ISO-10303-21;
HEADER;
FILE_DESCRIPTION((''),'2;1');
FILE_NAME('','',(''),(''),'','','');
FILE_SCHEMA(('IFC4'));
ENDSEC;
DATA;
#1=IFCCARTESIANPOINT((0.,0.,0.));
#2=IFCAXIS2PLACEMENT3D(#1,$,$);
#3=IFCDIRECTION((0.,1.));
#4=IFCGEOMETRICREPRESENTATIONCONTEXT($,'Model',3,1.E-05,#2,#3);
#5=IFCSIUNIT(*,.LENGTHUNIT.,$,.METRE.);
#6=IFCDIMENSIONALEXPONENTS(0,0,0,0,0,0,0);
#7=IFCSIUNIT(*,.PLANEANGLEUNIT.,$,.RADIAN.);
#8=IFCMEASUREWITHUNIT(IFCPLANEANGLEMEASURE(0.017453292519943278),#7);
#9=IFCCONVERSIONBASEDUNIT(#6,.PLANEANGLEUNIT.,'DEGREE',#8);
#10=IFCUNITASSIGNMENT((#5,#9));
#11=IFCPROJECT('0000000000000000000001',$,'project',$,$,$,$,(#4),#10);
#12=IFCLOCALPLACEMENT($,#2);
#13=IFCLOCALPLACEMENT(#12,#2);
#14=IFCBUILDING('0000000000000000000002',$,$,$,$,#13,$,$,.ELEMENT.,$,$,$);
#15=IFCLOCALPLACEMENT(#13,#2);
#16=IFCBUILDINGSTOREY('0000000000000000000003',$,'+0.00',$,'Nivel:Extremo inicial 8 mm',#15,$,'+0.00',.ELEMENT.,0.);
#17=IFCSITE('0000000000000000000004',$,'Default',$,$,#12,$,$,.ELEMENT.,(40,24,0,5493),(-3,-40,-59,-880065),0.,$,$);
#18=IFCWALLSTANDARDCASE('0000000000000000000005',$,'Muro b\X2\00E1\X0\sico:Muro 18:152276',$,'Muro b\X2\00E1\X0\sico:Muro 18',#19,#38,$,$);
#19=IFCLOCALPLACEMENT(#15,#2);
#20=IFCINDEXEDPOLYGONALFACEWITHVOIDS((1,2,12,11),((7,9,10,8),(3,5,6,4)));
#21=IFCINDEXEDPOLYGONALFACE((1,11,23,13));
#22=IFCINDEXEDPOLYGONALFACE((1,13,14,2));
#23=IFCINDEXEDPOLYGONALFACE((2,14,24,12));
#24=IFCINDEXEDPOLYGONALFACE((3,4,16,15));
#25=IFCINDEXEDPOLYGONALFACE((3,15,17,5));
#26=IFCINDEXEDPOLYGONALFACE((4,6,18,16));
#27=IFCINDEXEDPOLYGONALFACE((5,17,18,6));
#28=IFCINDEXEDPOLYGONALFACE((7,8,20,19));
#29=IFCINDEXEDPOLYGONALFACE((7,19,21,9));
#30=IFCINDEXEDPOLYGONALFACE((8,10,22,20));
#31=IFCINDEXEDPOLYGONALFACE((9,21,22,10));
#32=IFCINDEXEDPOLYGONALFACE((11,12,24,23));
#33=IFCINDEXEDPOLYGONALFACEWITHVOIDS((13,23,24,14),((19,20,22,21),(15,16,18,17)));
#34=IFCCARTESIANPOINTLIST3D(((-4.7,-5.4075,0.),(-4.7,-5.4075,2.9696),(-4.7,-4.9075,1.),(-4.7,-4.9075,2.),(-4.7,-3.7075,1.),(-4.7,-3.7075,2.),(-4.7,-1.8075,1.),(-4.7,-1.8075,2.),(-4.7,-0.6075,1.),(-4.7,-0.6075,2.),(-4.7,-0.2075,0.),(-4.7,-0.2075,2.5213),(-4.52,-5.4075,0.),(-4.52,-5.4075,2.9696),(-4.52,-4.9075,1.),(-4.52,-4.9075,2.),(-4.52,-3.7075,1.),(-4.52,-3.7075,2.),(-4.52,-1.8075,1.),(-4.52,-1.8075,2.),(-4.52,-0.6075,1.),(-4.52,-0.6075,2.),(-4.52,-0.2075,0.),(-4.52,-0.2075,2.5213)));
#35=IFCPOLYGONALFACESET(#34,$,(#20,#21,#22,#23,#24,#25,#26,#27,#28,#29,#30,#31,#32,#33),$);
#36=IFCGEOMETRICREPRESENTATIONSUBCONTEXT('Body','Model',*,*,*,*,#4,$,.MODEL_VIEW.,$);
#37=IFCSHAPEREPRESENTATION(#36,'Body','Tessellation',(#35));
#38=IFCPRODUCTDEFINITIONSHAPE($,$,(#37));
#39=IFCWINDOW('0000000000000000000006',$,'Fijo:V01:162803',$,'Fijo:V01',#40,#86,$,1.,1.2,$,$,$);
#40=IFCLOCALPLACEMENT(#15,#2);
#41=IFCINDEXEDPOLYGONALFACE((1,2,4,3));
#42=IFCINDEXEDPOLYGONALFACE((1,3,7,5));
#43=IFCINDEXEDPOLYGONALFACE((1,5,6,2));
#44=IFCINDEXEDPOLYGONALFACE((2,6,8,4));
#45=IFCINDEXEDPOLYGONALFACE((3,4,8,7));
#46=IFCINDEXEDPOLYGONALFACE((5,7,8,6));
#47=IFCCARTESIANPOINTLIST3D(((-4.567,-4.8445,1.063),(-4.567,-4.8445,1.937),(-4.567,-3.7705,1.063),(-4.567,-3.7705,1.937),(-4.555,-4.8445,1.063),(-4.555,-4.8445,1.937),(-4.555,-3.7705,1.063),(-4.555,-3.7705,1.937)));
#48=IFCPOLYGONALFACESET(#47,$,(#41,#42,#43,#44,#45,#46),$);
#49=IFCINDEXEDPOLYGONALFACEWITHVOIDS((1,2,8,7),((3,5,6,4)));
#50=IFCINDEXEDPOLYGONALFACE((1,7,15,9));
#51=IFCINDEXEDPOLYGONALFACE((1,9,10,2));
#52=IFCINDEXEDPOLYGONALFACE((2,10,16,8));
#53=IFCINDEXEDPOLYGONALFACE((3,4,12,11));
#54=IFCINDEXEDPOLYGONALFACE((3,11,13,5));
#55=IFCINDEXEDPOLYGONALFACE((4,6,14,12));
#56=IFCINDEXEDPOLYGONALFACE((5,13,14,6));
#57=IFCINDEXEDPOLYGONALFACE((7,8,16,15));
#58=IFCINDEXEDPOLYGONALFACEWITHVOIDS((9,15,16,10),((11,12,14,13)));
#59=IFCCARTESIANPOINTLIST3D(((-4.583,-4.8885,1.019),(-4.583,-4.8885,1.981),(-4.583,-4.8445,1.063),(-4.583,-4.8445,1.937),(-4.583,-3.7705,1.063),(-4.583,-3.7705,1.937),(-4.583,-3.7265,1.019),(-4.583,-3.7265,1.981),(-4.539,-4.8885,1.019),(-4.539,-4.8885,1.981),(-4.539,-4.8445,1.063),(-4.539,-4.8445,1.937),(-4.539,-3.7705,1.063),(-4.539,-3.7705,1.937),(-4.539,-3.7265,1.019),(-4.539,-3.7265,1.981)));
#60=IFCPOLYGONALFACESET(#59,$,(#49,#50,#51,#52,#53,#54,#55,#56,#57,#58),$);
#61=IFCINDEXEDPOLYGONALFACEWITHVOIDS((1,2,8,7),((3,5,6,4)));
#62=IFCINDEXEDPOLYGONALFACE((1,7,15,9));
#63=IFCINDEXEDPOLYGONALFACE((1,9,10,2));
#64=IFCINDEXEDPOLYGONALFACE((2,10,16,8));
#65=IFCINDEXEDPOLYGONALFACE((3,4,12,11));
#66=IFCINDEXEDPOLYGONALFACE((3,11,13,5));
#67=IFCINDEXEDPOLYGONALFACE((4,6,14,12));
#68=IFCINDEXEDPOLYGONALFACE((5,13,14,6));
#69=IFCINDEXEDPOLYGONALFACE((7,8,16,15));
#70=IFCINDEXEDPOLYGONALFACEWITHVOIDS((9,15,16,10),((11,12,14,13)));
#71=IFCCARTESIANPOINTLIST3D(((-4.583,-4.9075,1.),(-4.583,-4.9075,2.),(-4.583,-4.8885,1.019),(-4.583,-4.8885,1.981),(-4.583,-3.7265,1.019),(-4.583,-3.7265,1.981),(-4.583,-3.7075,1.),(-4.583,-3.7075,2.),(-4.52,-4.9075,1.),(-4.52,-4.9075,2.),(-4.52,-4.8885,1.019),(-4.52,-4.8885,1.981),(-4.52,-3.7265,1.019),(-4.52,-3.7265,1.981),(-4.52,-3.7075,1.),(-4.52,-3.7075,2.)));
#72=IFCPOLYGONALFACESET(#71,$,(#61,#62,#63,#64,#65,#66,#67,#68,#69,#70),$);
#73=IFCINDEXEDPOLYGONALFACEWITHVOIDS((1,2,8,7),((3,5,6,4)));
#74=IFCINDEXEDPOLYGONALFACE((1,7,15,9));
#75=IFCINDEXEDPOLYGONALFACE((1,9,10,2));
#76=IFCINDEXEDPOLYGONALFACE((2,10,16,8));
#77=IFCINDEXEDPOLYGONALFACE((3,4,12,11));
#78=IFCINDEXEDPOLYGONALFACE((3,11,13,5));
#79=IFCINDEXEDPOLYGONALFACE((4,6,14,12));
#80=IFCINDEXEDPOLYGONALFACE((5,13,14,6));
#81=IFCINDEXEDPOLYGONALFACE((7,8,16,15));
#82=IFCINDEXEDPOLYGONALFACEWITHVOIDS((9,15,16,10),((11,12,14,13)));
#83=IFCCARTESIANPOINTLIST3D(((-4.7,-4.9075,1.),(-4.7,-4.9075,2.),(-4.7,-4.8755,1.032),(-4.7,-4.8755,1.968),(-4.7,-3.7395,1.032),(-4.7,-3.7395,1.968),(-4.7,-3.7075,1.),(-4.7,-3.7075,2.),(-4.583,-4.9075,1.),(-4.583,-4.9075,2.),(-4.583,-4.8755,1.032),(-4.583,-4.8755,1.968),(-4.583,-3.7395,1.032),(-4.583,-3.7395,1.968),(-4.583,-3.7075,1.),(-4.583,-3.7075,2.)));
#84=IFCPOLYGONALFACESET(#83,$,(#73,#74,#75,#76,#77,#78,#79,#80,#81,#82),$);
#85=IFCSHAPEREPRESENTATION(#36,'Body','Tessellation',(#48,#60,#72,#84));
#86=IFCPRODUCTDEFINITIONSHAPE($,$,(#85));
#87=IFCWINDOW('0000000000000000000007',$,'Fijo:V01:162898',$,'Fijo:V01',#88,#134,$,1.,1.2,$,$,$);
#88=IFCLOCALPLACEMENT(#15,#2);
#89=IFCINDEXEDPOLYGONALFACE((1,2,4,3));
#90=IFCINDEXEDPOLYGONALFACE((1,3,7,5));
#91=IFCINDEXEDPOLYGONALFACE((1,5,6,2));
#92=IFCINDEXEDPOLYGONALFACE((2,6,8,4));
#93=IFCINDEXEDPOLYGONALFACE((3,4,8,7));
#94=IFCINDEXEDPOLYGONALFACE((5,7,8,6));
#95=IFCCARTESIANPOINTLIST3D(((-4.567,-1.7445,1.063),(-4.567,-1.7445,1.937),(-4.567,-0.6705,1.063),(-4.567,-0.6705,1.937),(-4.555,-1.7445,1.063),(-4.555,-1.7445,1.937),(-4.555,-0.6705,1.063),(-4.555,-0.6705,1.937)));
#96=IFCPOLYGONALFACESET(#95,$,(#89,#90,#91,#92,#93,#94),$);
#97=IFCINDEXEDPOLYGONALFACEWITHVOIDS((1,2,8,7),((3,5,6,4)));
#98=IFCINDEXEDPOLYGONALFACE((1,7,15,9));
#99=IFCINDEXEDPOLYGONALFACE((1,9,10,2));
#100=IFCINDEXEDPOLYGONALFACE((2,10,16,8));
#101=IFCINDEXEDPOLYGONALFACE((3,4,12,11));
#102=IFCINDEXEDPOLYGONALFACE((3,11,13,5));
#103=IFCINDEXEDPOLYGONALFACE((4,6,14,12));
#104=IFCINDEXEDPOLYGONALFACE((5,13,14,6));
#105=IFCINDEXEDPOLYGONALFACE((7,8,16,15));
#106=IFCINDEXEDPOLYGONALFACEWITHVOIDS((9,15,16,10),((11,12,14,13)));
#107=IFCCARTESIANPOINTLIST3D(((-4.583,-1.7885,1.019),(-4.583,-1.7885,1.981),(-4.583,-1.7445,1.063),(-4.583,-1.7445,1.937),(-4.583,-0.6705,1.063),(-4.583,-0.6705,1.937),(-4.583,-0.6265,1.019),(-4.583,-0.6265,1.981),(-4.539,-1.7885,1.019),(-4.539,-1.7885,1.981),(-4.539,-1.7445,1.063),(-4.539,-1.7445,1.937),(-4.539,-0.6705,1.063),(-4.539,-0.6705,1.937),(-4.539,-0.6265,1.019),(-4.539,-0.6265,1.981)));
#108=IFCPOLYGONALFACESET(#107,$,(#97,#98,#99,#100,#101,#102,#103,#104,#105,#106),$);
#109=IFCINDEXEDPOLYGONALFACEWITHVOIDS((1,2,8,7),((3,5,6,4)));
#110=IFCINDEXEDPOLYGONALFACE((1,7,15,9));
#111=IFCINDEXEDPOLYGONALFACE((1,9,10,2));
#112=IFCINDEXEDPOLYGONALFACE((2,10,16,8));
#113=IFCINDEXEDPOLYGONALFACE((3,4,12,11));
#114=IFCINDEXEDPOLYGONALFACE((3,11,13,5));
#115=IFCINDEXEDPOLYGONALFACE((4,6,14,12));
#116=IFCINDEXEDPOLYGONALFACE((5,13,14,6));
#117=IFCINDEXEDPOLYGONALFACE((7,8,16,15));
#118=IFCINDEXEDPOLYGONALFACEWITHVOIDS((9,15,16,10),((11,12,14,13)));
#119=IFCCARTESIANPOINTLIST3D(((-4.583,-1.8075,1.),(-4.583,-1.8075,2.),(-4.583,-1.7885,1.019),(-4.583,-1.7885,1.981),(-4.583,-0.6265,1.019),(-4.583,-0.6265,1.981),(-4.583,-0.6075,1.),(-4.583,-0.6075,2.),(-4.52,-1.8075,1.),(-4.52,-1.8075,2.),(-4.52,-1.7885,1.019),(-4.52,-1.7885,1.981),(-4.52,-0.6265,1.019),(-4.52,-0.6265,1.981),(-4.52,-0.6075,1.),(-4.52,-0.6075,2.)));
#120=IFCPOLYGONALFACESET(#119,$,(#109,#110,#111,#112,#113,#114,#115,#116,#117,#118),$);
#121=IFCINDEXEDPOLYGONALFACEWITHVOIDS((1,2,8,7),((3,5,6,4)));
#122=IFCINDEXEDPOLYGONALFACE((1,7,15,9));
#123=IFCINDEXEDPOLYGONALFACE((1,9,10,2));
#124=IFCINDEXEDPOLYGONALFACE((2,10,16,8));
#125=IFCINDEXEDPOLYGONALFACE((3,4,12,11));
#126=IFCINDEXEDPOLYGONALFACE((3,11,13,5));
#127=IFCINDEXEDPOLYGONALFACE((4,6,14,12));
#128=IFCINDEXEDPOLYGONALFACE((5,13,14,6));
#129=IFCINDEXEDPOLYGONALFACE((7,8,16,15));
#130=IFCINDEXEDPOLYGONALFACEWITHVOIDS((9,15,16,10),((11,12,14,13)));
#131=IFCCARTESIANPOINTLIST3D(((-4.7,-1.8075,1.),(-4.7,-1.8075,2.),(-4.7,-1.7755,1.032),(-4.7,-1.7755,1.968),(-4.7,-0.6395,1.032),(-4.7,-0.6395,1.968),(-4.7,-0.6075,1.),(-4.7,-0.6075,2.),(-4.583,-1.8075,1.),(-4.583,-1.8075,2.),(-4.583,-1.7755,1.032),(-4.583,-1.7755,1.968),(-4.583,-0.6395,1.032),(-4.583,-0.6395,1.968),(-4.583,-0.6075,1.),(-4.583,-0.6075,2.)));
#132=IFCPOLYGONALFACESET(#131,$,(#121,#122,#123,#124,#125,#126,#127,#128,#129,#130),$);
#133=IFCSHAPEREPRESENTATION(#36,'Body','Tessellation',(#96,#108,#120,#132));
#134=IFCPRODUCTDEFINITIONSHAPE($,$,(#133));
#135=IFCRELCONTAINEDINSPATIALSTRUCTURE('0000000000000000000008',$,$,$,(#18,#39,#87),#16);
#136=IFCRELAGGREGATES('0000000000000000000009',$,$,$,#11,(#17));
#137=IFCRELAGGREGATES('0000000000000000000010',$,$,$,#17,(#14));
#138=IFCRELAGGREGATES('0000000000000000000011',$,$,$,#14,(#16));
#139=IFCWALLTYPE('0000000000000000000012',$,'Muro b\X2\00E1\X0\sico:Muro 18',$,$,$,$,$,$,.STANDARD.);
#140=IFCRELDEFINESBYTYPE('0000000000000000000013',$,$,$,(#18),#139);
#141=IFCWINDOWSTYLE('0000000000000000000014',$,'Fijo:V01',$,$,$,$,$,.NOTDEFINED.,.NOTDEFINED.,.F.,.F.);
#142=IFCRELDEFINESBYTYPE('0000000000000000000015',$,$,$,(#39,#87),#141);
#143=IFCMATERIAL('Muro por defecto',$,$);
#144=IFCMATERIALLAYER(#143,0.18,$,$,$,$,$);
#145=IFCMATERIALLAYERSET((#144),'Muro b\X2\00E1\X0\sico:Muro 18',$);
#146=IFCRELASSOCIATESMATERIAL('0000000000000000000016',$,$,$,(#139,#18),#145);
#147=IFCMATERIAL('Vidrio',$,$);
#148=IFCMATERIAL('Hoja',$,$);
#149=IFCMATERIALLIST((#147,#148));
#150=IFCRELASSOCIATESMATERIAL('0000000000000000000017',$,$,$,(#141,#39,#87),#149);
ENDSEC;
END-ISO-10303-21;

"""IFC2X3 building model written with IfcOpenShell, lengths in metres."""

from ifc_helpers import new_model, entity, si_unit, converted_unit, direction, frame, frame_2d, origin, place, context, subcontext, project, spatial, polyline, rectangle, outline, extrude, clip, bounded_halfspace, source, transform, mapped, material, material_list, layer, layer_set, layer_usage, type_object, type_shapes, element, fill, save


model = new_model("IFC2X3")

# Units and contexts
model_context = context("Model", 3, precision=1e-05, world=origin(), true_north=direction((0.0, 1.0)))
body_context = subcontext(model_context, "Body", "Model", "MODEL_VIEW")
ifc_project = project(units=[si_unit("LENGTHUNIT", "METRE"), converted_unit("PLANEANGLEUNIT", "DEGREE", entity("IfcPlaneAngleMeasure", 0.017453292519943278), si_unit("PLANEANGLEUNIT", "RADIAN"), dimensions=[0, 0, 0, 0, 0, 0, 0])], contexts=[model_context])

# Site, building, storey
site_placement = place(None, origin())
site = spatial("IfcSite", under=ifc_project, at=site_placement, Name="Default", CompositionType="ELEMENT", RefLatitude=(40, 24, 0, 5493), RefLongitude=(-3, -40, -59, -880065), RefElevation=0.0)
building_placement = place(site_placement, origin())
building = spatial("IfcBuilding", under=site, at=building_placement, CompositionType="ELEMENT")
storey_placement = place(building_placement, origin())
storey = spatial("IfcBuildingStorey", under=building, at=storey_placement, Name="+0.00", ObjectType="Nivel:Extremo inicial 8 mm", LongName="+0.00", CompositionType="ELEMENT", Elevation=0.0)

# Wall, openings, windows
ifc_material_1 = material(Name="Muro por defecto")
ifc_layer = layer(ifc_material_1, 0.18)
ifc_layer_set = layer_set([ifc_layer], Name="Muro básico:Muro 18")
ifc_layer_usage_1 = layer_usage(ifc_layer_set, "AXIS2", "POSITIVE", -0.09)
wall_type = type_object("IfcWallType", Name="Muro básico:Muro 18", PredefinedType="STANDARD", material=ifc_layer_set)
wall_1_placement = place(storey_placement, frame((-4.61, -0.2075, 0.0), z_axis=(0.0, 0.0, 1.0), x_axis=(0.0, -1.0, 0.0)))
wall_1 = element("IfcWallStandardCase", 1, at=wall_1_placement, inside=storey, type_object=wall_type, material=ifc_layer_usage_1, Name="Muro básico:Muro 18:152276", ObjectType="Muro básico:Muro 18", context=body_context, shape_type="Clipping", body=[
    clip(extrude(rectangle(XDim=5.2, YDim=0.18, at=frame_2d((2.6, 0.0), x_axis=(-1.0, 0.0))), origin(), (0.0, 0.0, 1.0), 2.9696), bounded_halfspace(frame((0.0, -0.09, 2.5213), z_axis=(-0.085882, 0.0, 0.996305), x_axis=(0.0, -1.0, 0.0)), False, frame((0.0, -0.09, 2.5213)), polyline([(0.0, 0.0), (5.2, 0.0), (5.2, 0.18), (0.0, 0.18), (0.0, 0.0)]))),
])
opening_1_placement = place(wall_1_placement, frame((3.5, -0.09, 1.0)))
opening_1 = element("IfcOpeningElement", 2, at=opening_1_placement, cuts=wall_1, ObjectType="Opening", context=body_context, shape_type="SweptSolid", body=[
    extrude(rectangle(XDim=1.0, YDim=1.2, at=frame_2d((0.5, 0.6), x_axis=(1.0, 0.0))), frame((0.0, 0.0, 0.0), z_axis=(0.0, 1.0, 0.0), x_axis=(0.0, 0.0, 1.0)), (0.0, 0.0, 1.0), 0.18),
])
opening_2_placement = place(wall_1_placement, frame((0.4, -0.09, 1.0)))
opening_2 = element("IfcOpeningElement", 3, at=opening_2_placement, cuts=wall_1, ObjectType="Opening", context=body_context, shape_type="SweptSolid", body=[
    extrude(rectangle(XDim=1.0, YDim=1.2, at=frame_2d((0.5, 0.6), x_axis=(1.0, 0.0))), frame((0.0, 0.0, 0.0), z_axis=(0.0, 1.0, 0.0), x_axis=(0.0, 0.0, 1.0)), (0.0, 0.0, 1.0), 0.18),
])
ifc_material_2 = material(Name="Vidrio")
ifc_material_3 = material(Name="Hoja")
ifc_material_list_1 = material_list([ifc_material_2, ifc_material_3])
window_style_1 = type_object("IfcWindowStyle", Name="Fijo:V01", ConstructionType="NOTDEFINED", OperationType="NOTDEFINED", ParameterTakesPrecedence=False, Sizeable=False, material=ifc_material_list_1)
shared_shape_1 = source(origin(), body_context, "Body", "SweptSolid", [
    extrude(rectangle(XDim=0.012, YDim=1.074, at=frame_2d((0.0, 0.0), x_axis=(1.0, 0.0))), frame((0.6, 0.139, 0.063), z_axis=(0.0, 0.0, 1.0), x_axis=(0.0, -1.0, 0.0)), (0.0, 0.0, 1.0), 0.874),
    extrude(outline(polyline([(-0.581, -0.481), (0.581, -0.481), (0.581, 0.481), (-0.581, 0.481), (-0.581, -0.481)]), holes=[polyline([(-0.537, -0.437), (-0.537, 0.437), (0.537, 0.437), (0.537, -0.437), (-0.537, -0.437)])]), frame((0.6, 0.117, 0.5), z_axis=(0.0, 1.0, 0.0), x_axis=(1.0, 0.0, 0.0)), (0.0, 0.0, 1.0), 0.044),
    extrude(outline(polyline([(-0.6, -0.5), (0.6, -0.5), (0.6, 0.5), (-0.6, 0.5), (-0.6, -0.5)]), holes=[polyline([(-0.581, -0.481), (-0.581, 0.481), (0.581, 0.481), (0.581, -0.481), (-0.581, -0.481)])]), frame((0.6, 0.117, 0.5), z_axis=(0.0, 1.0, 0.0), x_axis=(1.0, 0.0, 0.0)), (0.0, 0.0, 1.0), 0.063),
    extrude(outline(polyline([(-0.6, -0.5), (0.6, -0.5), (0.6, 0.5), (-0.6, 0.5), (-0.6, -0.5)]), holes=[polyline([(-0.568, -0.468), (-0.568, 0.468), (0.568, 0.468), (0.568, -0.468), (-0.568, -0.468)])]), frame((0.6, 0.0, 0.5), z_axis=(0.0, 1.0, 0.0), x_axis=(1.0, 0.0, 0.0)), (0.0, 0.0, 1.0), 0.117),
])
type_shapes(window_style_1, [shared_shape_1])
window_1_placement = place(opening_1_placement, origin())
window_1 = element("IfcWindow", 4, at=window_1_placement, inside=storey, type_object=window_style_1, material=ifc_material_list_1, Name="Fijo:V01:162803", ObjectType="Fijo:V01", OverallHeight=1.0, OverallWidth=1.2, context=body_context, shape_type="MappedRepresentation", body=[
    mapped(shared_shape_1, transform((0.0, 0.0, 0.0), scale=1.0)),
])
fill(opening_1, window_1)
window_2_placement = place(opening_2_placement, origin())
window_2 = element("IfcWindow", 5, at=window_2_placement, inside=storey, type_object=window_style_1, material=ifc_material_list_1, Name="Fijo:V01:162898", ObjectType="Fijo:V01", OverallHeight=1.0, OverallWidth=1.2, context=body_context, shape_type="MappedRepresentation", body=[
    mapped(shared_shape_1, transform((0.0, 0.0, 0.0), scale=1.0)),
])
fill(opening_2, window_2)

save(model, "model.ifc")
